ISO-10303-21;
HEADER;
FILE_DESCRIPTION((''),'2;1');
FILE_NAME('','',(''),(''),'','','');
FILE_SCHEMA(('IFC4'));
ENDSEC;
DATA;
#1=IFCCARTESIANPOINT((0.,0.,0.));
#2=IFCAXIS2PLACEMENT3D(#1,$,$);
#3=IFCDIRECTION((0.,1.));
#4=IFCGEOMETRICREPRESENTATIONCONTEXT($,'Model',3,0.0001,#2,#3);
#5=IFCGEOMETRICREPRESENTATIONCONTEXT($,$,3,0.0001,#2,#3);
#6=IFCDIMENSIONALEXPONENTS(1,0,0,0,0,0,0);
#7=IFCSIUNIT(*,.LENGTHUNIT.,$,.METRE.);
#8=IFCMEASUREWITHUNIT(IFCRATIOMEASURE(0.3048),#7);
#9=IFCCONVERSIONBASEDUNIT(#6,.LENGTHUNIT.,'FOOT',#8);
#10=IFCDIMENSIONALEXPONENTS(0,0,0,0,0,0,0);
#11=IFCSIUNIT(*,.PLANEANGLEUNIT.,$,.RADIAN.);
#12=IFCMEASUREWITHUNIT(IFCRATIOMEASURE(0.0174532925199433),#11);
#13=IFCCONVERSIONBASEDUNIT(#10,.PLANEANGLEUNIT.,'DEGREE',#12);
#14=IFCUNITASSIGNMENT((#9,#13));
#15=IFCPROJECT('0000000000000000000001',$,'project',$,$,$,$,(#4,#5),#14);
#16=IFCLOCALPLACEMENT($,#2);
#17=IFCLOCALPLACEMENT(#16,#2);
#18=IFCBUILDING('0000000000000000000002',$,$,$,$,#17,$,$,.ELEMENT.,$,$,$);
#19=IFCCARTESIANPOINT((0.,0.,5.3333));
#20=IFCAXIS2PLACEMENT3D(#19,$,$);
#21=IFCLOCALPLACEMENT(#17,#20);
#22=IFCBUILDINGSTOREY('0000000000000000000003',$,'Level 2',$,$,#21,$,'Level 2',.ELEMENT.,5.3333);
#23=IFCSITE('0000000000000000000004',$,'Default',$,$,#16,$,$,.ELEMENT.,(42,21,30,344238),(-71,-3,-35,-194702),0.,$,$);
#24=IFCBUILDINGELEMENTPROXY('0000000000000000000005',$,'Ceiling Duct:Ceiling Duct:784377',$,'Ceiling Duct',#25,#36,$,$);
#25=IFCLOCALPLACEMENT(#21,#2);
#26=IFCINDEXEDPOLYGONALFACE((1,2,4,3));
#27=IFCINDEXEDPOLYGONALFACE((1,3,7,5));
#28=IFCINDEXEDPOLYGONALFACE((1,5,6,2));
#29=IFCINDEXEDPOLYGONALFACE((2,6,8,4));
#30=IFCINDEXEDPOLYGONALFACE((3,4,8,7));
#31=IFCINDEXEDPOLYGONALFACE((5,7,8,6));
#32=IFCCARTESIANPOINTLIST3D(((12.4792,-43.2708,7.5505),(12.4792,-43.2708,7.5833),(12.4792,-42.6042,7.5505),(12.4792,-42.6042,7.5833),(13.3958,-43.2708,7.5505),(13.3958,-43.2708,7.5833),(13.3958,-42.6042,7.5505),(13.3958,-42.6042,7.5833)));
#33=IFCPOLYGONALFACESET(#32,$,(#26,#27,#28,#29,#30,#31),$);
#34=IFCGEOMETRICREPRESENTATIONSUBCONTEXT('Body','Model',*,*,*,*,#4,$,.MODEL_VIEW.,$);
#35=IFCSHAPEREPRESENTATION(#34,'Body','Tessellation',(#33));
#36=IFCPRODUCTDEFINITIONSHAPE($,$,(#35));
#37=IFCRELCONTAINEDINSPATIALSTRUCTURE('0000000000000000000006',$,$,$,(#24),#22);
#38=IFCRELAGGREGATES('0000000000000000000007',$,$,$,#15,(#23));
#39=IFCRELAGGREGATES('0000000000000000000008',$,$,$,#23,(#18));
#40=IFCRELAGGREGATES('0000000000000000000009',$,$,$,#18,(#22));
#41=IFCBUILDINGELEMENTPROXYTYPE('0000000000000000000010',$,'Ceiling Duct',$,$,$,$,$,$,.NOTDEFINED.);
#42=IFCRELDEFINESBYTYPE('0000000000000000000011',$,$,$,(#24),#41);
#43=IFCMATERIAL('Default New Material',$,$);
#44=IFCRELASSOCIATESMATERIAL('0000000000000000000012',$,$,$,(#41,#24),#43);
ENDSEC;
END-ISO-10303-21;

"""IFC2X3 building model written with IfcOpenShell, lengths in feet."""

from ifc_helpers import new_model, entity, si_unit, converted_unit, direction, frame, frame_2d, origin, place, context, subcontext, project, spatial, rectangle, extrude, source, transform, mapped, material, type_object, type_shapes, element, save


model = new_model("IFC2X3")

# Units and contexts
model_context = context("Model", 3, precision=0.0001, world=origin(), true_north=direction((0.0, 1.0)))
context_of_model = context(None, 3, precision=0.0001, world=origin(), true_north=direction((0.0, 1.0)))
body_context = subcontext(model_context, "Body", "Model", "MODEL_VIEW")
ifc_project = project(units=[converted_unit("LENGTHUNIT", "FOOT", entity("IfcRatioMeasure", 0.3048), si_unit("LENGTHUNIT", "METRE"), dimensions=[1, 0, 0, 0, 0, 0, 0]), converted_unit("PLANEANGLEUNIT", "DEGREE", entity("IfcRatioMeasure", 0.0174532925199433), si_unit("PLANEANGLEUNIT", "RADIAN"), dimensions=[0, 0, 0, 0, 0, 0, 0])], contexts=[model_context, context_of_model])

# Site, building, storey
site_placement = place(None, origin())
site = spatial("IfcSite", under=ifc_project, at=site_placement, Name="Default", CompositionType="ELEMENT", RefLatitude=(42, 21, 30, 344238), RefLongitude=(-71, -3, -35, -194702), RefElevation=0.0)
building_placement = place(site_placement, origin())
building = spatial("IfcBuilding", under=site, at=building_placement, CompositionType="ELEMENT")
storey_placement = place(building_placement, frame((0.0, 0.0, 5.3333)))
storey = spatial("IfcBuildingStorey", under=building, at=storey_placement, Name="Level 2", LongName="Level 2", CompositionType="ELEMENT", Elevation=5.3333)

# Shared definitions
ifc_material_1 = material(Name="Default New Material")

# Building element proxy
building_element_proxy_type_1 = type_object("IfcBuildingElementProxyType", Name="Ceiling Duct", PredefinedType="NOTDEFINED", material=ifc_material_1)
shared_shape_1 = source(origin(), body_context, "Body", "SweptSolid", [
    extrude(rectangle(XDim=0.6667, YDim=0.9167, at=frame_2d((0.0, 0.0), x_axis=(1.0, 0.0))), frame((0.4583, -0.3333, -0.0329), z_axis=(0.0, 0.0, 1.0), x_axis=(0.0, 1.0, 0.0)), (0.0, 0.0, 1.0), 0.0329),
])
type_shapes(building_element_proxy_type_1, [shared_shape_1])
proxy_1_placement = place(storey_placement, frame((12.4792, -42.6042, 7.5833)))
element("IfcBuildingElementProxy", 1, at=proxy_1_placement, inside=storey, type_object=building_element_proxy_type_1, material=ifc_material_1, Name="Ceiling Duct:Ceiling Duct:784377", ObjectType="Ceiling Duct", context=body_context, shape_type="MappedRepresentation", body=[
    mapped(shared_shape_1, transform((0.0, 0.0, 0.0), scale=1.0)),
])

save(model, "model.ifc")
